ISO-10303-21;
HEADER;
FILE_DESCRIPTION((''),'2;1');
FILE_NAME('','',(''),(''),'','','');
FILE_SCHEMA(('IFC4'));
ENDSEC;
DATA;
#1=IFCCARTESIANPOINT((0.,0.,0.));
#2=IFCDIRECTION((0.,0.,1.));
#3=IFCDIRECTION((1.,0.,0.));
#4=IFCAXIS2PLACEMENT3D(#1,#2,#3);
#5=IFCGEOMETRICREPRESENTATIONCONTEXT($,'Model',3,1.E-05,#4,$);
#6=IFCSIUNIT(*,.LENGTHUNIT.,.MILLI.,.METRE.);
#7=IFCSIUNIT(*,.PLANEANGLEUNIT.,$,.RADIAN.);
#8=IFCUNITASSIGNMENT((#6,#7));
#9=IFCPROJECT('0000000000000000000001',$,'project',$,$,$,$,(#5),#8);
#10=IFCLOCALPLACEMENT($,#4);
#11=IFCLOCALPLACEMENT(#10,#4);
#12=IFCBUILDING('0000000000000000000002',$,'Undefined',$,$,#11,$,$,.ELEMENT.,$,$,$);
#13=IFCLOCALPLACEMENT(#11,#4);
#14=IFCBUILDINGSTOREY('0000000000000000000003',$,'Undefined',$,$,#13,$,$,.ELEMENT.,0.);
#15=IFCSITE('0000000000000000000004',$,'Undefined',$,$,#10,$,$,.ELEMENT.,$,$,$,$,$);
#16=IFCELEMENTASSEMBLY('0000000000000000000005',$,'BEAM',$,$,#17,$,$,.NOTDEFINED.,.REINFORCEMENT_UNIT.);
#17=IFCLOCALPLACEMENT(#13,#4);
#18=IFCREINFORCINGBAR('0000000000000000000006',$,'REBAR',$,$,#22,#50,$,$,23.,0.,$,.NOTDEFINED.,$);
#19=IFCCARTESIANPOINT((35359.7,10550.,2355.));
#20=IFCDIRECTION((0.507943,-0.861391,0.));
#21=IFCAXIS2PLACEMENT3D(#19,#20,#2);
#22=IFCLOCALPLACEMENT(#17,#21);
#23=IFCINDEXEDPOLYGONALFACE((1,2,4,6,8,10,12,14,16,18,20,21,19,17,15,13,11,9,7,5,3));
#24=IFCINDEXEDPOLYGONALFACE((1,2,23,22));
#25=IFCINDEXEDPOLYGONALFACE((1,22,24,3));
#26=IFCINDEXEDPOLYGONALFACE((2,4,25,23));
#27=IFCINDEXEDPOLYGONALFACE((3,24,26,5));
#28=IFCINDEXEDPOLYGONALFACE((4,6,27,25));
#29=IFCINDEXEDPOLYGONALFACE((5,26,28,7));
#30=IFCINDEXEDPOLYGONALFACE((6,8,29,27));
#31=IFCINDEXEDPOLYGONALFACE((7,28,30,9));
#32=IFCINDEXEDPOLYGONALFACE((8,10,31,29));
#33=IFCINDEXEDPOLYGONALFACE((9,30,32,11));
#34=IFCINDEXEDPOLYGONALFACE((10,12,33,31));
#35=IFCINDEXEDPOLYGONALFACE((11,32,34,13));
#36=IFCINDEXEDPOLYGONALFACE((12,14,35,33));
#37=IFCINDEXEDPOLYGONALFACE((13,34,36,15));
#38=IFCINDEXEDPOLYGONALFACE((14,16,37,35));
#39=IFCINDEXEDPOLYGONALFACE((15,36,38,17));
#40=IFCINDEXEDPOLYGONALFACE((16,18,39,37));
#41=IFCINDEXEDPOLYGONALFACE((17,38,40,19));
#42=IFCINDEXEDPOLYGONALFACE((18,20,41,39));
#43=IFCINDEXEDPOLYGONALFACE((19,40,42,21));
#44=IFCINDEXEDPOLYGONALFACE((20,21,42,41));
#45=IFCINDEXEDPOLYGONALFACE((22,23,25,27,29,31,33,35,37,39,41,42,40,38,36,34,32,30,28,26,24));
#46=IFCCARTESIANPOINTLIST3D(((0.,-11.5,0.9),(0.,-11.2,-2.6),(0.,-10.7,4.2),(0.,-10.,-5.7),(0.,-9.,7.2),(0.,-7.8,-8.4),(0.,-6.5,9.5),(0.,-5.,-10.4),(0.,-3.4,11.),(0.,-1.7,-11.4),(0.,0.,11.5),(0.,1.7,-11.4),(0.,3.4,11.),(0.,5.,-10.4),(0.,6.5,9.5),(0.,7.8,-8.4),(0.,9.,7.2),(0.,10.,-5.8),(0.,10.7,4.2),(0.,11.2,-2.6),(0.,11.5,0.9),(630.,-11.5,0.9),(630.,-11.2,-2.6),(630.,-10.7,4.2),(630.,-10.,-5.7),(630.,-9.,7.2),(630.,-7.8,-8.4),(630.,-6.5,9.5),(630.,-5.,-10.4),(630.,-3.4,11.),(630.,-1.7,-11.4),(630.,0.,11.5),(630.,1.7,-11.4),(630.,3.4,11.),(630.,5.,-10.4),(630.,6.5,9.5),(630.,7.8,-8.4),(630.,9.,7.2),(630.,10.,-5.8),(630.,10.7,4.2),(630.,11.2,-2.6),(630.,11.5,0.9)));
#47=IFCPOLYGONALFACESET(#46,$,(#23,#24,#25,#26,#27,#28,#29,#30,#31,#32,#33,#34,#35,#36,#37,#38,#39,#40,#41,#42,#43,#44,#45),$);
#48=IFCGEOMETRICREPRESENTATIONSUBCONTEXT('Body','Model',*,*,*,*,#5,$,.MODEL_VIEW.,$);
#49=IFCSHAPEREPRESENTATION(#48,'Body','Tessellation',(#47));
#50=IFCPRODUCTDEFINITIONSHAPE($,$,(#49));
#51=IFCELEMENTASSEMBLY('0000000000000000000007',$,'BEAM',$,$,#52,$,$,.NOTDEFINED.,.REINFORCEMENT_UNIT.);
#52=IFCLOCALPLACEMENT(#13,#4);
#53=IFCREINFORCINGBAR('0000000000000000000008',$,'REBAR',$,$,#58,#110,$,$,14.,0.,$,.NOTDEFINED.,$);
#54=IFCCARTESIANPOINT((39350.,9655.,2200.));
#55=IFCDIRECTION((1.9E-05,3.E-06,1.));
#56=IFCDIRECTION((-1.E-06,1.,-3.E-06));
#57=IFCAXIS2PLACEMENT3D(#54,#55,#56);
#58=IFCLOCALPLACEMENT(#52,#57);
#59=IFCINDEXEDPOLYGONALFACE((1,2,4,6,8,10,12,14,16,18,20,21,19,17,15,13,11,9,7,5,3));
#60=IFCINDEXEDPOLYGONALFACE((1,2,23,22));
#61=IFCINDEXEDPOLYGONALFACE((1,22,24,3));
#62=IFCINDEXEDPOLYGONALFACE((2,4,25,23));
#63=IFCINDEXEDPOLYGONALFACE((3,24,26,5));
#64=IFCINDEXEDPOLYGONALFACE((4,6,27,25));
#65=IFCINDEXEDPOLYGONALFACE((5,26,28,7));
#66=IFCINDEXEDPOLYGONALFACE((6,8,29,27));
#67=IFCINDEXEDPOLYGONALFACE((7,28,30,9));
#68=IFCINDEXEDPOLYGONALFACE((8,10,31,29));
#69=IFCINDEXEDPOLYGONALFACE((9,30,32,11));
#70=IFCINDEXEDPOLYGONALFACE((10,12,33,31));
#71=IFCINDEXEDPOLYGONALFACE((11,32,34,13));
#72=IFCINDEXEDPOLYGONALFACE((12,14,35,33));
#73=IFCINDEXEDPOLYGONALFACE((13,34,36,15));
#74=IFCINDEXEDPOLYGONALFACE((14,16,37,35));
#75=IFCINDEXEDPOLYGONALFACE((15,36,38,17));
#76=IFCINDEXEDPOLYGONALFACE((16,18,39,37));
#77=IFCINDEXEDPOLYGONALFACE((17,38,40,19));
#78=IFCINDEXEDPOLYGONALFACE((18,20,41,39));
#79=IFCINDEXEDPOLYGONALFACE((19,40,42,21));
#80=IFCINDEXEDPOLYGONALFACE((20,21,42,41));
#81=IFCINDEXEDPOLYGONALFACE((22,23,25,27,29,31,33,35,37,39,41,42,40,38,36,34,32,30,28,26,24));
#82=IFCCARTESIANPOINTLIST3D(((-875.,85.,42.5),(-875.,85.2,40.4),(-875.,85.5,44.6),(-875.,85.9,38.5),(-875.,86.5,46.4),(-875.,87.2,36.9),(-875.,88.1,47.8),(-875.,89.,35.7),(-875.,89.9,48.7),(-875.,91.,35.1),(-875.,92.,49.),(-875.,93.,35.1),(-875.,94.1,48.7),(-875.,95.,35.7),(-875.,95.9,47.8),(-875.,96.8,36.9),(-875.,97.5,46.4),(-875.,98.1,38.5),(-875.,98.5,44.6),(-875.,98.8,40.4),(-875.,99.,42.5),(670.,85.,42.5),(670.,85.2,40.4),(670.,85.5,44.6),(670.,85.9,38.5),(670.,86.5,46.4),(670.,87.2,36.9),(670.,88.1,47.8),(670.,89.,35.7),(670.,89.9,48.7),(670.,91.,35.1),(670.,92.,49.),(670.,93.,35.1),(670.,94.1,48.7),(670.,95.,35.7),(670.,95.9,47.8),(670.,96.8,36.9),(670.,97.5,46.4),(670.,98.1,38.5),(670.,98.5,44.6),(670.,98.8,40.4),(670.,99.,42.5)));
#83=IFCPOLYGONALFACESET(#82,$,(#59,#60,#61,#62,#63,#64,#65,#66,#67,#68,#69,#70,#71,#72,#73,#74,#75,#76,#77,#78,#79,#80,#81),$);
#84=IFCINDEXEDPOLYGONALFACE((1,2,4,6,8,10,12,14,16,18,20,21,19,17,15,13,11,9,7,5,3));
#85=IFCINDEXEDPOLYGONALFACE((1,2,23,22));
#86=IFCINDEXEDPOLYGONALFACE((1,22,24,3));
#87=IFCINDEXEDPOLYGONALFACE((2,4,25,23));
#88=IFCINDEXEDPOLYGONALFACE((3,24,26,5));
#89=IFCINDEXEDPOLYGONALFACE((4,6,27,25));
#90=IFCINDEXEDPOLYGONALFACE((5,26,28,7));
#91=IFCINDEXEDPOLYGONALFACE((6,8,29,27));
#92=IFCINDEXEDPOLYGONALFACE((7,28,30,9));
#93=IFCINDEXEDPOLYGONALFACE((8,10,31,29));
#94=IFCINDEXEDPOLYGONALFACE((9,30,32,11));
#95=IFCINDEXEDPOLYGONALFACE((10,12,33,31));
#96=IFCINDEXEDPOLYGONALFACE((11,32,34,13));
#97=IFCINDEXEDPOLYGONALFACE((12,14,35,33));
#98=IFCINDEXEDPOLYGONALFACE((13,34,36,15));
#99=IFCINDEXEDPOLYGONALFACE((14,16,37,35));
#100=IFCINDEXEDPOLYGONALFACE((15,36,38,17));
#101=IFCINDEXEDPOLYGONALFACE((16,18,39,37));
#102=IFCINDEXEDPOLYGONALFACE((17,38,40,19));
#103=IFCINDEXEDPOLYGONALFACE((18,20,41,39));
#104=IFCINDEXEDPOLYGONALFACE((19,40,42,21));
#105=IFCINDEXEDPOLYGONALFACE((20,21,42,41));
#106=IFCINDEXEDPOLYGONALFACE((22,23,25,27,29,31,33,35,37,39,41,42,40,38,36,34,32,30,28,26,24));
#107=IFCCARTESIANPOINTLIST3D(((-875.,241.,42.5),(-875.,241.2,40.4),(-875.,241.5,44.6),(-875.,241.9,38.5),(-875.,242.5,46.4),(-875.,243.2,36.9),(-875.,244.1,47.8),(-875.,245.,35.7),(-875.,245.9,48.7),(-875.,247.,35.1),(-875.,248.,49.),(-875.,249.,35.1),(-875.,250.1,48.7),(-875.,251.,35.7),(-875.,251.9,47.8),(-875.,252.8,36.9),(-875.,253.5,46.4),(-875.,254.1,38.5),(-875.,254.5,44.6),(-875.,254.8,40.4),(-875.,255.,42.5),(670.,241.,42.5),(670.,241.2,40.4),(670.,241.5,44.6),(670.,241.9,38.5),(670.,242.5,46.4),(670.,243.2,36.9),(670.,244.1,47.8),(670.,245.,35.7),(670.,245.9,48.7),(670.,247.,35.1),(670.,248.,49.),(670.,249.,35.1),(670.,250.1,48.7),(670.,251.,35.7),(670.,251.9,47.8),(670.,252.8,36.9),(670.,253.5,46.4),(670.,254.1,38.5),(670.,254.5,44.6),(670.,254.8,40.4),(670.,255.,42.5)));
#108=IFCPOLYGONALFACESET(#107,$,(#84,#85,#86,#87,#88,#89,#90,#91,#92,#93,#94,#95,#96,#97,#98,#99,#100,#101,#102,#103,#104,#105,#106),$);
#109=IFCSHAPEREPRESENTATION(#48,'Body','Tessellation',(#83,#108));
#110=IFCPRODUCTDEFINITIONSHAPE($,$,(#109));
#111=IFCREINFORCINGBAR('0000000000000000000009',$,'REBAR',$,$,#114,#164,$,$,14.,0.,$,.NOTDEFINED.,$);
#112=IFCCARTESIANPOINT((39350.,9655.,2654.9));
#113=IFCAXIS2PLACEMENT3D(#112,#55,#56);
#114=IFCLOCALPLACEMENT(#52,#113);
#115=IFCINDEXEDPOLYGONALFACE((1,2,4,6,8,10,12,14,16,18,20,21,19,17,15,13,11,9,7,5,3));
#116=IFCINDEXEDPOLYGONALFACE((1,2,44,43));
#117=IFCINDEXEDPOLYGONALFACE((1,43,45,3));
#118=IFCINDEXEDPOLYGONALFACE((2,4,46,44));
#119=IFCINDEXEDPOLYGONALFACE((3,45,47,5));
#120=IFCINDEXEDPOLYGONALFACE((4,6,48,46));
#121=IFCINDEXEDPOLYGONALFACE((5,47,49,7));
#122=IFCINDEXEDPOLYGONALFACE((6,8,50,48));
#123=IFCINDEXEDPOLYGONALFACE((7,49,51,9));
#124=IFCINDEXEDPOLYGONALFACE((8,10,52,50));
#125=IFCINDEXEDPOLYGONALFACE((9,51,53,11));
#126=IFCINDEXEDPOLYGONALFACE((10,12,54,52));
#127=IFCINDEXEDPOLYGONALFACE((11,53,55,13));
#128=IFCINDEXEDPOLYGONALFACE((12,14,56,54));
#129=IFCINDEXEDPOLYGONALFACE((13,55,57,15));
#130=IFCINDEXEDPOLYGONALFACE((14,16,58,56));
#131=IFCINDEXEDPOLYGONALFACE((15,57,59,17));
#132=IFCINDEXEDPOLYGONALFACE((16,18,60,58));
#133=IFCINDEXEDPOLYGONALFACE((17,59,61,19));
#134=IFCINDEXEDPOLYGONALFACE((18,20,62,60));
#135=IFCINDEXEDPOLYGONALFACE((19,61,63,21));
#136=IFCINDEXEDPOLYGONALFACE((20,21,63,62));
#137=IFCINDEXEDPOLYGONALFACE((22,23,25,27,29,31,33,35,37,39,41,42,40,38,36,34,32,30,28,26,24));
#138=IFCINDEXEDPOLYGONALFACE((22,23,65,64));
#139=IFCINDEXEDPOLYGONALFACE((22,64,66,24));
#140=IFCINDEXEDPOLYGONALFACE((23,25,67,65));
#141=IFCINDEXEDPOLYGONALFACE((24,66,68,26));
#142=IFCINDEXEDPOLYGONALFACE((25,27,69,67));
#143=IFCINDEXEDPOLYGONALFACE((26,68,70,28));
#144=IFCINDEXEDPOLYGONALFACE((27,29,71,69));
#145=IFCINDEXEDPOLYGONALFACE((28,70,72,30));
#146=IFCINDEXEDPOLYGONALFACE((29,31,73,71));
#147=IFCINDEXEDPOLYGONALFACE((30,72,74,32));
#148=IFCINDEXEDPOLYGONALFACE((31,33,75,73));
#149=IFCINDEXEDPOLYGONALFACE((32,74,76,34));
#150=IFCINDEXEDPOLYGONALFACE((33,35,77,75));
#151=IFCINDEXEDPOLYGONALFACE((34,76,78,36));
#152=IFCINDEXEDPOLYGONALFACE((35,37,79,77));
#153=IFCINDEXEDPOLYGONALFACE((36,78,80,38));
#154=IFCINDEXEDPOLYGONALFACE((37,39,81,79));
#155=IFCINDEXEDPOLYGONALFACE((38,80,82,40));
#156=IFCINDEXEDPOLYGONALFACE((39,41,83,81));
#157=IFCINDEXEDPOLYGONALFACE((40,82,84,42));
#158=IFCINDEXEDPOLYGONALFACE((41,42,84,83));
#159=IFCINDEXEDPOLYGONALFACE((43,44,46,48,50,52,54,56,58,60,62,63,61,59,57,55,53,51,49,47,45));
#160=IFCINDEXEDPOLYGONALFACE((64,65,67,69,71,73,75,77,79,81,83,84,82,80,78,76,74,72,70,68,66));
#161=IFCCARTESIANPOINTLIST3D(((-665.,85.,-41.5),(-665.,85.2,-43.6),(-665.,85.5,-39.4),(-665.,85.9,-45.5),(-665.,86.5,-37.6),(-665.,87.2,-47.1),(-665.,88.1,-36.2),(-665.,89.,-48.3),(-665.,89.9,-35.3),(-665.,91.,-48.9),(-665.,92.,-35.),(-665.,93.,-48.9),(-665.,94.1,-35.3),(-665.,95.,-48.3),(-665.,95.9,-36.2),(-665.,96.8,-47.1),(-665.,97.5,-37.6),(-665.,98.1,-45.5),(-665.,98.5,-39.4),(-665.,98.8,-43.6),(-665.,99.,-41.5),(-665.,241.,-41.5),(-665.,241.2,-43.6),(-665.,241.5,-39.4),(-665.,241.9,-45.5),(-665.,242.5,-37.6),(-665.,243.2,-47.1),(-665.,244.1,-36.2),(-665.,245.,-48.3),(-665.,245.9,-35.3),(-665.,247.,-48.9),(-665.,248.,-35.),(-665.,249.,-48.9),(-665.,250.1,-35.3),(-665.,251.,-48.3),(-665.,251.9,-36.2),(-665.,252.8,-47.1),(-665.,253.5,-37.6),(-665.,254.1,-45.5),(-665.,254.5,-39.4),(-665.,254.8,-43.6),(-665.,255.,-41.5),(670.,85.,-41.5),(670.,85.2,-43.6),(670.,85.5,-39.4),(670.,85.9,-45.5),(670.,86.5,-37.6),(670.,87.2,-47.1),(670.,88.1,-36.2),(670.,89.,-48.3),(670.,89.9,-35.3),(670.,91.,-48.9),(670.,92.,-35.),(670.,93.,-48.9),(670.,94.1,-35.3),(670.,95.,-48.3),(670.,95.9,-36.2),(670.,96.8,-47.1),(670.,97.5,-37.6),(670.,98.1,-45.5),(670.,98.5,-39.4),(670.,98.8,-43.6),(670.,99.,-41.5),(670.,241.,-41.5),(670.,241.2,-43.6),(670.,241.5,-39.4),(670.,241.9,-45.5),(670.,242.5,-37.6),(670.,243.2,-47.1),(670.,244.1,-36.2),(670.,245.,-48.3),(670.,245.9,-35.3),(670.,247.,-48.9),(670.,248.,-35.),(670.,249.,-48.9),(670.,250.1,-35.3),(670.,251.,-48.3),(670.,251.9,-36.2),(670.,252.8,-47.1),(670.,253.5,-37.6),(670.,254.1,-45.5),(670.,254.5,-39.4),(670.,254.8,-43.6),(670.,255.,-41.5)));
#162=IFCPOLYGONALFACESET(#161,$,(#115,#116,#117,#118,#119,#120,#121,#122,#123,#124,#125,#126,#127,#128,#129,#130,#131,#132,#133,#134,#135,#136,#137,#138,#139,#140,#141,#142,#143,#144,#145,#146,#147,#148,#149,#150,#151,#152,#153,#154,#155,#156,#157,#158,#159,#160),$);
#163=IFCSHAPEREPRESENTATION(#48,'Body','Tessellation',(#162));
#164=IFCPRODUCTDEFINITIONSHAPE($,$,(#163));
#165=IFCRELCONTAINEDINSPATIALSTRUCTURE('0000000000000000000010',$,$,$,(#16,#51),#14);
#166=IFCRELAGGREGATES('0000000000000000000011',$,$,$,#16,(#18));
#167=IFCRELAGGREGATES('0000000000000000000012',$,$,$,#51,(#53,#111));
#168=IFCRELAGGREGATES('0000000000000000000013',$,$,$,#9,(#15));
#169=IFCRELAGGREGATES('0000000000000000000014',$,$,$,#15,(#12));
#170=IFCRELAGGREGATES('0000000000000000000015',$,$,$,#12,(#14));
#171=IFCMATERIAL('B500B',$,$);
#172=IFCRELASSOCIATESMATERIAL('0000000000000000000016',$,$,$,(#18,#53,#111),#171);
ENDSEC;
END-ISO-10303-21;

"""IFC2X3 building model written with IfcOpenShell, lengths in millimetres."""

from ifc_helpers import new_model, entity, si_unit, frame, origin_with_axes, place, context, subcontext, project, spatial, source, transform, mapped, material, element, aggregate, save


model = new_model("IFC2X3")

# Units and contexts
model_context = context("Model", 3, precision=1e-05, world=origin_with_axes())
body_context = subcontext(model_context, "Body", "Model", "MODEL_VIEW")
ifc_project = project(units=[si_unit("LENGTHUNIT", "METRE", prefix="MILLI"), si_unit("PLANEANGLEUNIT", "RADIAN")], contexts=[model_context])

# Site, building, storey
site_placement = place(None, origin_with_axes())
site = spatial("IfcSite", under=ifc_project, at=site_placement, Name="Undefined", CompositionType="ELEMENT")
building_placement = place(site_placement, origin_with_axes())
building = spatial("IfcBuilding", under=site, at=building_placement, Name="Undefined", CompositionType="ELEMENT")
storey_placement = place(building_placement, origin_with_axes())
storey = spatial("IfcBuildingStorey", under=building, at=storey_placement, Name="Undefined", CompositionType="ELEMENT", Elevation=0.0)

# Shared definitions
ifc_material_1 = material(Name="B500B")

# Element assemblies, reinforcing bars
assembly_1_placement = place(storey_placement, origin_with_axes())
assembly_1 = element("IfcElementAssembly", 1, at=assembly_1_placement, inside=storey, Name="BEAM", AssemblyPlace="NOTDEFINED", PredefinedType="REINFORCEMENT_UNIT")
shared_shape_1 = source(origin_with_axes(), body_context, "Body", "AdvancedSweptSolid", [
    entity("IfcSweptDiskSolid", entity("IfcTrimmedCurve", entity("IfcLine", entity("IfcCartesianPoint", [0.0, 0.0, 0.0]), entity("IfcVector", entity("IfcDirection", [1.0, 0.0, 0.0]), 1.0)), [entity("IfcParameterValue", 0.0)], [entity("IfcParameterValue", 630.0)], True, "PARAMETER"), 11.5, None, 0.0, 630.0),
])
reinforcing_bar_1_placement = place(assembly_1_placement, frame((35359.7, 10550.0, 2355.0), z_axis=(0.507943, -0.861391, 0.0), x_axis=(0.0, 0.0, 1.0)))
reinforcing_bar_1 = element("IfcReinforcingBar", 2, at=reinforcing_bar_1_placement, material=ifc_material_1, Name="REBAR", BarRole="NOTDEFINED", CrossSectionArea=0.0, NominalDiameter=23.0, context=body_context, shape_type="MappedRepresentation", body=[
    mapped(shared_shape_1, transform((0.0, 0.0, 0.0))),
])
aggregate(assembly_1, [reinforcing_bar_1])
assembly_2_placement = place(storey_placement, origin_with_axes())
assembly_2 = element("IfcElementAssembly", 3, at=assembly_2_placement, inside=storey, Name="BEAM", AssemblyPlace="NOTDEFINED", PredefinedType="REINFORCEMENT_UNIT")
shared_shape_2 = source(origin_with_axes(), body_context, "Body", "AdvancedSweptSolid", [
    entity("IfcSweptDiskSolid", entity("IfcTrimmedCurve", entity("IfcLine", entity("IfcCartesianPoint", [0.0, 0.0, 0.0]), entity("IfcVector", entity("IfcDirection", [1.0, 0.0, 0.0]), 1.0)), [entity("IfcParameterValue", 0.0)], [entity("IfcParameterValue", 1544.999613)], True, "PARAMETER"), 7.0, None, 0.0, 1545.0),
])
shared_shape_3 = source(origin_with_axes(), body_context, "Body", "AdvancedSweptSolid", [
    entity("IfcSweptDiskSolid", entity("IfcTrimmedCurve", entity("IfcLine", entity("IfcCartesianPoint", [0.0, 0.0, 0.0]), entity("IfcVector", entity("IfcDirection", [1.0, 0.0, 0.0]), 1.0)), [entity("IfcParameterValue", 0.0)], [entity("IfcParameterValue", 1544.999613)], True, "PARAMETER"), 7.0, None, 0.0, 1545.0),
])
reinforcing_bar_2_placement = place(assembly_2_placement, frame((39350.0, 9655.0, 2200.0), z_axis=(0.000019, 0.000003, 1.0), x_axis=(-0.000001, 1.0, -0.000003)))
reinforcing_bar_2 = element("IfcReinforcingBar", 4, at=reinforcing_bar_2_placement, material=ifc_material_1, Name="REBAR", BarRole="NOTDEFINED", CrossSectionArea=0.0, NominalDiameter=14.0, context=body_context, shape_type="MappedRepresentation", body=[
    mapped(shared_shape_2, transform((-875.0, 92.0, 42.0))),
    mapped(shared_shape_3, transform((-875.0, 248.0, 42.0))),
])
shared_shape_4 = source(origin_with_axes(), body_context, "Body", "AdvancedSweptSolid", [
    entity("IfcSweptDiskSolid", entity("IfcTrimmedCurve", entity("IfcLine", entity("IfcCartesianPoint", [0.0, 0.0, 0.0]), entity("IfcVector", entity("IfcDirection", [1.0, 0.0, 0.0]), 1.0)), [entity("IfcParameterValue", 0.0)], [entity("IfcParameterValue", 1335.009613)], True, "PARAMETER"), 7.0, None, 0.0, 1335.0),
])
shared_shape_5 = source(origin_with_axes(), body_context, "Body", "AdvancedSweptSolid", [
    entity("IfcSweptDiskSolid", entity("IfcTrimmedCurve", entity("IfcLine", entity("IfcCartesianPoint", [0.0, 0.0, 0.0]), entity("IfcVector", entity("IfcDirection", [1.0, 0.0, 0.0]), 1.0)), [entity("IfcParameterValue", 0.0)], [entity("IfcParameterValue", 1335.009613)], True, "PARAMETER"), 7.0, None, 0.0, 1335.0),
])
reinforcing_bar_3_placement = place(assembly_2_placement, frame((39350.0, 9655.0, 2654.9), z_axis=(0.000019, 0.000003, 1.0), x_axis=(-0.000001, 1.0, -0.000003)))
reinforcing_bar_3 = element("IfcReinforcingBar", 5, at=reinforcing_bar_3_placement, material=ifc_material_1, Name="REBAR", BarRole="NOTDEFINED", CrossSectionArea=0.0, NominalDiameter=14.0, context=body_context, shape_type="MappedRepresentation", body=[
    mapped(shared_shape_4, transform((-665.0, 92.0, -42.0))),
    mapped(shared_shape_5, transform((-665.0, 248.0, -42.0))),
])
aggregate(assembly_2, [reinforcing_bar_2, reinforcing_bar_3])

save(model, "model.ifc")
